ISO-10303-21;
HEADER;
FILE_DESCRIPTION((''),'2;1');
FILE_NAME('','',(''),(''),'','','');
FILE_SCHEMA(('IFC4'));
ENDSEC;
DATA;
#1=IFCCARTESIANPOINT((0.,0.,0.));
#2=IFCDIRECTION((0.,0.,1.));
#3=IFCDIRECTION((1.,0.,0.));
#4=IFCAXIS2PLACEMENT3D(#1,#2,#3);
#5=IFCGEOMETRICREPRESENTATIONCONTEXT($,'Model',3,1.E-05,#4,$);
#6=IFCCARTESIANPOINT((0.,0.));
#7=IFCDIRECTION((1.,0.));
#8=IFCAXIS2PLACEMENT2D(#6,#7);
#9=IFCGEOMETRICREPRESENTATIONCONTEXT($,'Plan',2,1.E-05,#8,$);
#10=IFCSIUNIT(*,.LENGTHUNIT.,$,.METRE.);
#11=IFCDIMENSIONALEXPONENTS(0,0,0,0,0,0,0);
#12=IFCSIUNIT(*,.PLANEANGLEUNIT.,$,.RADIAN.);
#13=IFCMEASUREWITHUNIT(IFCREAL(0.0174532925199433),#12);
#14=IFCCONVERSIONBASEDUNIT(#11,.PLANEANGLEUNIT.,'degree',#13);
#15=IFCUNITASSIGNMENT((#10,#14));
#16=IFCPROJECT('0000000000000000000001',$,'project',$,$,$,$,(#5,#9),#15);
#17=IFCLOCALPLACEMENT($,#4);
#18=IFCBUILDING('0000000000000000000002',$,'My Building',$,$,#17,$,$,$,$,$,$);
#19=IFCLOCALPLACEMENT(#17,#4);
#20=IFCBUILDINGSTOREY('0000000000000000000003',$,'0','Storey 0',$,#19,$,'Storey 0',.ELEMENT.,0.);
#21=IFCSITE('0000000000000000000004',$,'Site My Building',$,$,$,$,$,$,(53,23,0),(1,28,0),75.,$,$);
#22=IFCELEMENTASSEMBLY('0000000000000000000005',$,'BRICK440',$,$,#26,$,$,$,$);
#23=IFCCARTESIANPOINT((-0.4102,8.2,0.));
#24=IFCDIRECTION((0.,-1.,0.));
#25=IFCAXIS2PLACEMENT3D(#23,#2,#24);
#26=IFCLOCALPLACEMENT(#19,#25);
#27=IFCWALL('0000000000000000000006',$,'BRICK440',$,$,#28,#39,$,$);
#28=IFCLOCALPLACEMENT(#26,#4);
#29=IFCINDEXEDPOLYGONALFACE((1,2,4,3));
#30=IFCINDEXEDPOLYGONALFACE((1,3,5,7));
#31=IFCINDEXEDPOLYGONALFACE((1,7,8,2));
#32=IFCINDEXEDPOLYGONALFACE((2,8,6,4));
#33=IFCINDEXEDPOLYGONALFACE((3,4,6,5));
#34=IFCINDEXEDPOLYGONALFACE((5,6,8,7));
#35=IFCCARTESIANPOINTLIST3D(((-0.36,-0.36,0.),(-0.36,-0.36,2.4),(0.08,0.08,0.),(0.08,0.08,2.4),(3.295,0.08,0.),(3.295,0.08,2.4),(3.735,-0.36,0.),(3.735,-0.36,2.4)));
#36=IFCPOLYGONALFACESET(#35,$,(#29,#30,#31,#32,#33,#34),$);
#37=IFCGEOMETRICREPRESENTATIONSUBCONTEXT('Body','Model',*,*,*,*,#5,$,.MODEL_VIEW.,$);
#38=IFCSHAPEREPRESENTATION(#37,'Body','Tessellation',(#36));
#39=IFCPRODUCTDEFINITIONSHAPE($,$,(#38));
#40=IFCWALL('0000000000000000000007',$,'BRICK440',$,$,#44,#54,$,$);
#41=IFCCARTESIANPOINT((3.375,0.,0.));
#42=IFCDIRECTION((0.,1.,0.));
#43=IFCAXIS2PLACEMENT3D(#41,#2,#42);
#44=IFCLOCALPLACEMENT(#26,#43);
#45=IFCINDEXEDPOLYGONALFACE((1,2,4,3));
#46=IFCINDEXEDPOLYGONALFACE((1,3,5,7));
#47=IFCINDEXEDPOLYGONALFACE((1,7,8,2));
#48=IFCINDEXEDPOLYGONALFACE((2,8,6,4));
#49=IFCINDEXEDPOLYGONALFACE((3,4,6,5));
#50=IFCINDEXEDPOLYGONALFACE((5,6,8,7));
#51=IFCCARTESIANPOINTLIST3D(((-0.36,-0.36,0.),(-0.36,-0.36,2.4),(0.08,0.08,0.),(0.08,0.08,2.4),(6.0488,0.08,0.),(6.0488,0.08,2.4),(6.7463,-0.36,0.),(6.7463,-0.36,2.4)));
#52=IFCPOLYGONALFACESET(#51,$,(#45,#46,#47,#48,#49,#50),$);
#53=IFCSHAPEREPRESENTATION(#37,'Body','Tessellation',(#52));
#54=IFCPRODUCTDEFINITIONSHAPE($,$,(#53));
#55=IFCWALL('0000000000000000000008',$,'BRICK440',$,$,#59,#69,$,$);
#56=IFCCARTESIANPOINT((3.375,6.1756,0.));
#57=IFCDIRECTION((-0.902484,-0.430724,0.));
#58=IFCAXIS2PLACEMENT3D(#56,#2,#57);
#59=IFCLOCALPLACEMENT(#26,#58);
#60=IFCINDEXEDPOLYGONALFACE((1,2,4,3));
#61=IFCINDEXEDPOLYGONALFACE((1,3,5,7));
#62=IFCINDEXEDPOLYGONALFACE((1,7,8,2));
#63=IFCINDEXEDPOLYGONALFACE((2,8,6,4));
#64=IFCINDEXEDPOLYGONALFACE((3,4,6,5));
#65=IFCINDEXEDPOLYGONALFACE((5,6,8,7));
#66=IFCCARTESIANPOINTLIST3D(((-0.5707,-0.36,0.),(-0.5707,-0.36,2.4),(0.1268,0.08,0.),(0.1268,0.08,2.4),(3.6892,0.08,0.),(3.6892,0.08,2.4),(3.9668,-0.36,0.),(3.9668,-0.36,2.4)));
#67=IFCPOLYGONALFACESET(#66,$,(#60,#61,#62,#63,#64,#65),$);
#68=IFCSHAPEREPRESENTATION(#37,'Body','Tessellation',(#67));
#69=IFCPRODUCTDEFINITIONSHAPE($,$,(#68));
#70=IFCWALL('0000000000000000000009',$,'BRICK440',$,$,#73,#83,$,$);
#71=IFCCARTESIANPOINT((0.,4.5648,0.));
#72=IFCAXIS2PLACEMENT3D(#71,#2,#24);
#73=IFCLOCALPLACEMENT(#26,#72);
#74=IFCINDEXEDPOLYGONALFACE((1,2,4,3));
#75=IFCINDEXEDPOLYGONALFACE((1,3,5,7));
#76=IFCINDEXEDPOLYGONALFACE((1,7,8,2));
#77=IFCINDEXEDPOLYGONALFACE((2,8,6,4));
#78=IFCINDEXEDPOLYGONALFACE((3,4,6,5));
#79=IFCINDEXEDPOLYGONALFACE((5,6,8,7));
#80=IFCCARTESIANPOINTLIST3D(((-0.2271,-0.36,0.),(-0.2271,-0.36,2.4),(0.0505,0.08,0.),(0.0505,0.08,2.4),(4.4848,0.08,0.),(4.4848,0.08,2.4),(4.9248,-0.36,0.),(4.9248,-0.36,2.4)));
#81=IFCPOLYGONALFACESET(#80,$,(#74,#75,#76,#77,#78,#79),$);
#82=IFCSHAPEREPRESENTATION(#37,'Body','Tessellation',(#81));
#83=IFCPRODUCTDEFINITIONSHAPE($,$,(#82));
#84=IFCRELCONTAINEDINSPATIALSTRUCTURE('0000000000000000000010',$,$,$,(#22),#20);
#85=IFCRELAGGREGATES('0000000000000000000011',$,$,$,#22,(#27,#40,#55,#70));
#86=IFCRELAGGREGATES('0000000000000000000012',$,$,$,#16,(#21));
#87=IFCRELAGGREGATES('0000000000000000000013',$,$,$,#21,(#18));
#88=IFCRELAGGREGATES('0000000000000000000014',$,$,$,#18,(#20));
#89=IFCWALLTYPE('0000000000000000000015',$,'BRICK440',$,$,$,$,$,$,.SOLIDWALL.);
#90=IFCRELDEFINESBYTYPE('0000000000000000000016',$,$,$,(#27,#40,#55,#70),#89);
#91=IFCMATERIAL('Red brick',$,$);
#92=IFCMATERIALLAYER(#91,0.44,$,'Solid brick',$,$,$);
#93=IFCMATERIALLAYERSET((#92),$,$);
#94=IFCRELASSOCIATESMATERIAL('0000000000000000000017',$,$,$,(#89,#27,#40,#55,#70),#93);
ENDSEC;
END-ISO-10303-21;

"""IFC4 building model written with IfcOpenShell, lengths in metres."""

from ifc_helpers import new_model, entity, si_unit, converted_unit, frame, origin, origin_with_axes, origin_2d_with_axis, place, context, subcontext, project, spatial, polyline, outline, extrude, material, layer, layer_set, layer_usage, type_object, element, aggregate, save


model = new_model("IFC4")

# Units and contexts
model_context = context("Model", 3, precision=1e-05, world=origin_with_axes())
plan_context = context("Plan", 2, precision=1e-05, world=origin_2d_with_axis())
body_context = subcontext(model_context, "Body", "Model", "MODEL_VIEW")
ifc_project = project(units=[si_unit("LENGTHUNIT", "METRE"), converted_unit("PLANEANGLEUNIT", "degree", entity("IfcReal", 0.0174532925199433), si_unit("PLANEANGLEUNIT", "RADIAN"), dimensions=[0, 0, 0, 0, 0, 0, 0])], contexts=[model_context, plan_context])

# Site, building, storey
site = spatial("IfcSite", under=ifc_project, Name="Site My Building", RefLatitude=(53, 23, 0), RefLongitude=(1, 28, 0), RefElevation=75.0)
building_placement = place(None, origin_with_axes())
building = spatial("IfcBuilding", under=site, at=building_placement, Name="My Building")
storey_placement = place(building_placement, origin_with_axes())
storey = spatial("IfcBuildingStorey", under=building, at=storey_placement, Name="0", Description="Storey 0", LongName="Storey 0", CompositionType="ELEMENT", Elevation=0.0)

# Element assembly, walls
assembly_1_placement = place(storey_placement, frame((-0.4102, 8.2, 0.0), z_axis=(0.0, 0.0, 1.0), x_axis=(0.0, -1.0, 0.0)))
assembly_1 = element("IfcElementAssembly", 1, at=assembly_1_placement, inside=storey, Name="BRICK440")
ifc_material_1 = material(Name="Red brick")
ifc_layer_1 = layer(ifc_material_1, 0.44, Name="Solid brick")
ifc_layer_set_1 = layer_set([ifc_layer_1])
ifc_layer_usage_1 = layer_usage(ifc_layer_set_1, "AXIS2", "POSITIVE", -0.36)
wall_type = type_object("IfcWallType", Name="BRICK440", PredefinedType="SOLIDWALL", material=ifc_layer_set_1)
wall_1_placement = place(assembly_1_placement, origin_with_axes())
wall_1 = element("IfcWall", 2, at=wall_1_placement, type_object=wall_type, material=ifc_layer_usage_1, Name="BRICK440", context=body_context, shape_type="SweptSolid", body=[
    extrude(outline(polyline([(0.08, 0.08), (-0.36, -0.36), (3.735, -0.36), (3.295, 0.08), (0.08, 0.08)])), origin(), (0.0, 0.0, 1.0), 2.4),
])
ifc_layer_usage_2 = layer_usage(ifc_layer_set_1, "AXIS2", "POSITIVE", -0.36)
wall_2_placement = place(assembly_1_placement, frame((3.375, 0.0, 0.0), z_axis=(0.0, 0.0, 1.0), x_axis=(0.0, 1.0, 0.0)))
wall_2 = element("IfcWall", 3, at=wall_2_placement, type_object=wall_type, material=ifc_layer_usage_2, Name="BRICK440", context=body_context, shape_type="SweptSolid", body=[
    extrude(outline(polyline([(0.08, 0.08), (-0.36, -0.36), (6.7463, -0.36), (6.0488, 0.08), (0.08, 0.08)])), origin(), (0.0, 0.0, 1.0), 2.4),
])
ifc_layer_usage_3 = layer_usage(ifc_layer_set_1, "AXIS2", "POSITIVE", -0.36)
wall_3_placement = place(assembly_1_placement, frame((3.375, 6.1756, 0.0), z_axis=(0.0, 0.0, 1.0), x_axis=(-0.902484, -0.430724, 0.0)))
wall_3 = element("IfcWall", 4, at=wall_3_placement, type_object=wall_type, material=ifc_layer_usage_3, Name="BRICK440", context=body_context, shape_type="SweptSolid", body=[
    extrude(outline(polyline([(0.1268, 0.08), (-0.5707, -0.36), (3.9668, -0.36), (3.6892, 0.08), (0.1268, 0.08)])), origin(), (0.0, 0.0, 1.0), 2.4),
])
ifc_layer_usage_4 = layer_usage(ifc_layer_set_1, "AXIS2", "POSITIVE", -0.36)
wall_4_placement = place(assembly_1_placement, frame((0.0, 4.5648, 0.0), z_axis=(0.0, 0.0, 1.0), x_axis=(0.0, -1.0, 0.0)))
wall_4 = element("IfcWall", 5, at=wall_4_placement, type_object=wall_type, material=ifc_layer_usage_4, Name="BRICK440", context=body_context, shape_type="SweptSolid", body=[
    extrude(outline(polyline([(0.0505, 0.08), (-0.2271, -0.36), (4.9248, -0.36), (4.4848, 0.08), (0.0505, 0.08)])), origin(), (0.0, 0.0, 1.0), 2.4),
])
aggregate(assembly_1, [wall_1, wall_2, wall_3, wall_4])

save(model, "model.ifc")
